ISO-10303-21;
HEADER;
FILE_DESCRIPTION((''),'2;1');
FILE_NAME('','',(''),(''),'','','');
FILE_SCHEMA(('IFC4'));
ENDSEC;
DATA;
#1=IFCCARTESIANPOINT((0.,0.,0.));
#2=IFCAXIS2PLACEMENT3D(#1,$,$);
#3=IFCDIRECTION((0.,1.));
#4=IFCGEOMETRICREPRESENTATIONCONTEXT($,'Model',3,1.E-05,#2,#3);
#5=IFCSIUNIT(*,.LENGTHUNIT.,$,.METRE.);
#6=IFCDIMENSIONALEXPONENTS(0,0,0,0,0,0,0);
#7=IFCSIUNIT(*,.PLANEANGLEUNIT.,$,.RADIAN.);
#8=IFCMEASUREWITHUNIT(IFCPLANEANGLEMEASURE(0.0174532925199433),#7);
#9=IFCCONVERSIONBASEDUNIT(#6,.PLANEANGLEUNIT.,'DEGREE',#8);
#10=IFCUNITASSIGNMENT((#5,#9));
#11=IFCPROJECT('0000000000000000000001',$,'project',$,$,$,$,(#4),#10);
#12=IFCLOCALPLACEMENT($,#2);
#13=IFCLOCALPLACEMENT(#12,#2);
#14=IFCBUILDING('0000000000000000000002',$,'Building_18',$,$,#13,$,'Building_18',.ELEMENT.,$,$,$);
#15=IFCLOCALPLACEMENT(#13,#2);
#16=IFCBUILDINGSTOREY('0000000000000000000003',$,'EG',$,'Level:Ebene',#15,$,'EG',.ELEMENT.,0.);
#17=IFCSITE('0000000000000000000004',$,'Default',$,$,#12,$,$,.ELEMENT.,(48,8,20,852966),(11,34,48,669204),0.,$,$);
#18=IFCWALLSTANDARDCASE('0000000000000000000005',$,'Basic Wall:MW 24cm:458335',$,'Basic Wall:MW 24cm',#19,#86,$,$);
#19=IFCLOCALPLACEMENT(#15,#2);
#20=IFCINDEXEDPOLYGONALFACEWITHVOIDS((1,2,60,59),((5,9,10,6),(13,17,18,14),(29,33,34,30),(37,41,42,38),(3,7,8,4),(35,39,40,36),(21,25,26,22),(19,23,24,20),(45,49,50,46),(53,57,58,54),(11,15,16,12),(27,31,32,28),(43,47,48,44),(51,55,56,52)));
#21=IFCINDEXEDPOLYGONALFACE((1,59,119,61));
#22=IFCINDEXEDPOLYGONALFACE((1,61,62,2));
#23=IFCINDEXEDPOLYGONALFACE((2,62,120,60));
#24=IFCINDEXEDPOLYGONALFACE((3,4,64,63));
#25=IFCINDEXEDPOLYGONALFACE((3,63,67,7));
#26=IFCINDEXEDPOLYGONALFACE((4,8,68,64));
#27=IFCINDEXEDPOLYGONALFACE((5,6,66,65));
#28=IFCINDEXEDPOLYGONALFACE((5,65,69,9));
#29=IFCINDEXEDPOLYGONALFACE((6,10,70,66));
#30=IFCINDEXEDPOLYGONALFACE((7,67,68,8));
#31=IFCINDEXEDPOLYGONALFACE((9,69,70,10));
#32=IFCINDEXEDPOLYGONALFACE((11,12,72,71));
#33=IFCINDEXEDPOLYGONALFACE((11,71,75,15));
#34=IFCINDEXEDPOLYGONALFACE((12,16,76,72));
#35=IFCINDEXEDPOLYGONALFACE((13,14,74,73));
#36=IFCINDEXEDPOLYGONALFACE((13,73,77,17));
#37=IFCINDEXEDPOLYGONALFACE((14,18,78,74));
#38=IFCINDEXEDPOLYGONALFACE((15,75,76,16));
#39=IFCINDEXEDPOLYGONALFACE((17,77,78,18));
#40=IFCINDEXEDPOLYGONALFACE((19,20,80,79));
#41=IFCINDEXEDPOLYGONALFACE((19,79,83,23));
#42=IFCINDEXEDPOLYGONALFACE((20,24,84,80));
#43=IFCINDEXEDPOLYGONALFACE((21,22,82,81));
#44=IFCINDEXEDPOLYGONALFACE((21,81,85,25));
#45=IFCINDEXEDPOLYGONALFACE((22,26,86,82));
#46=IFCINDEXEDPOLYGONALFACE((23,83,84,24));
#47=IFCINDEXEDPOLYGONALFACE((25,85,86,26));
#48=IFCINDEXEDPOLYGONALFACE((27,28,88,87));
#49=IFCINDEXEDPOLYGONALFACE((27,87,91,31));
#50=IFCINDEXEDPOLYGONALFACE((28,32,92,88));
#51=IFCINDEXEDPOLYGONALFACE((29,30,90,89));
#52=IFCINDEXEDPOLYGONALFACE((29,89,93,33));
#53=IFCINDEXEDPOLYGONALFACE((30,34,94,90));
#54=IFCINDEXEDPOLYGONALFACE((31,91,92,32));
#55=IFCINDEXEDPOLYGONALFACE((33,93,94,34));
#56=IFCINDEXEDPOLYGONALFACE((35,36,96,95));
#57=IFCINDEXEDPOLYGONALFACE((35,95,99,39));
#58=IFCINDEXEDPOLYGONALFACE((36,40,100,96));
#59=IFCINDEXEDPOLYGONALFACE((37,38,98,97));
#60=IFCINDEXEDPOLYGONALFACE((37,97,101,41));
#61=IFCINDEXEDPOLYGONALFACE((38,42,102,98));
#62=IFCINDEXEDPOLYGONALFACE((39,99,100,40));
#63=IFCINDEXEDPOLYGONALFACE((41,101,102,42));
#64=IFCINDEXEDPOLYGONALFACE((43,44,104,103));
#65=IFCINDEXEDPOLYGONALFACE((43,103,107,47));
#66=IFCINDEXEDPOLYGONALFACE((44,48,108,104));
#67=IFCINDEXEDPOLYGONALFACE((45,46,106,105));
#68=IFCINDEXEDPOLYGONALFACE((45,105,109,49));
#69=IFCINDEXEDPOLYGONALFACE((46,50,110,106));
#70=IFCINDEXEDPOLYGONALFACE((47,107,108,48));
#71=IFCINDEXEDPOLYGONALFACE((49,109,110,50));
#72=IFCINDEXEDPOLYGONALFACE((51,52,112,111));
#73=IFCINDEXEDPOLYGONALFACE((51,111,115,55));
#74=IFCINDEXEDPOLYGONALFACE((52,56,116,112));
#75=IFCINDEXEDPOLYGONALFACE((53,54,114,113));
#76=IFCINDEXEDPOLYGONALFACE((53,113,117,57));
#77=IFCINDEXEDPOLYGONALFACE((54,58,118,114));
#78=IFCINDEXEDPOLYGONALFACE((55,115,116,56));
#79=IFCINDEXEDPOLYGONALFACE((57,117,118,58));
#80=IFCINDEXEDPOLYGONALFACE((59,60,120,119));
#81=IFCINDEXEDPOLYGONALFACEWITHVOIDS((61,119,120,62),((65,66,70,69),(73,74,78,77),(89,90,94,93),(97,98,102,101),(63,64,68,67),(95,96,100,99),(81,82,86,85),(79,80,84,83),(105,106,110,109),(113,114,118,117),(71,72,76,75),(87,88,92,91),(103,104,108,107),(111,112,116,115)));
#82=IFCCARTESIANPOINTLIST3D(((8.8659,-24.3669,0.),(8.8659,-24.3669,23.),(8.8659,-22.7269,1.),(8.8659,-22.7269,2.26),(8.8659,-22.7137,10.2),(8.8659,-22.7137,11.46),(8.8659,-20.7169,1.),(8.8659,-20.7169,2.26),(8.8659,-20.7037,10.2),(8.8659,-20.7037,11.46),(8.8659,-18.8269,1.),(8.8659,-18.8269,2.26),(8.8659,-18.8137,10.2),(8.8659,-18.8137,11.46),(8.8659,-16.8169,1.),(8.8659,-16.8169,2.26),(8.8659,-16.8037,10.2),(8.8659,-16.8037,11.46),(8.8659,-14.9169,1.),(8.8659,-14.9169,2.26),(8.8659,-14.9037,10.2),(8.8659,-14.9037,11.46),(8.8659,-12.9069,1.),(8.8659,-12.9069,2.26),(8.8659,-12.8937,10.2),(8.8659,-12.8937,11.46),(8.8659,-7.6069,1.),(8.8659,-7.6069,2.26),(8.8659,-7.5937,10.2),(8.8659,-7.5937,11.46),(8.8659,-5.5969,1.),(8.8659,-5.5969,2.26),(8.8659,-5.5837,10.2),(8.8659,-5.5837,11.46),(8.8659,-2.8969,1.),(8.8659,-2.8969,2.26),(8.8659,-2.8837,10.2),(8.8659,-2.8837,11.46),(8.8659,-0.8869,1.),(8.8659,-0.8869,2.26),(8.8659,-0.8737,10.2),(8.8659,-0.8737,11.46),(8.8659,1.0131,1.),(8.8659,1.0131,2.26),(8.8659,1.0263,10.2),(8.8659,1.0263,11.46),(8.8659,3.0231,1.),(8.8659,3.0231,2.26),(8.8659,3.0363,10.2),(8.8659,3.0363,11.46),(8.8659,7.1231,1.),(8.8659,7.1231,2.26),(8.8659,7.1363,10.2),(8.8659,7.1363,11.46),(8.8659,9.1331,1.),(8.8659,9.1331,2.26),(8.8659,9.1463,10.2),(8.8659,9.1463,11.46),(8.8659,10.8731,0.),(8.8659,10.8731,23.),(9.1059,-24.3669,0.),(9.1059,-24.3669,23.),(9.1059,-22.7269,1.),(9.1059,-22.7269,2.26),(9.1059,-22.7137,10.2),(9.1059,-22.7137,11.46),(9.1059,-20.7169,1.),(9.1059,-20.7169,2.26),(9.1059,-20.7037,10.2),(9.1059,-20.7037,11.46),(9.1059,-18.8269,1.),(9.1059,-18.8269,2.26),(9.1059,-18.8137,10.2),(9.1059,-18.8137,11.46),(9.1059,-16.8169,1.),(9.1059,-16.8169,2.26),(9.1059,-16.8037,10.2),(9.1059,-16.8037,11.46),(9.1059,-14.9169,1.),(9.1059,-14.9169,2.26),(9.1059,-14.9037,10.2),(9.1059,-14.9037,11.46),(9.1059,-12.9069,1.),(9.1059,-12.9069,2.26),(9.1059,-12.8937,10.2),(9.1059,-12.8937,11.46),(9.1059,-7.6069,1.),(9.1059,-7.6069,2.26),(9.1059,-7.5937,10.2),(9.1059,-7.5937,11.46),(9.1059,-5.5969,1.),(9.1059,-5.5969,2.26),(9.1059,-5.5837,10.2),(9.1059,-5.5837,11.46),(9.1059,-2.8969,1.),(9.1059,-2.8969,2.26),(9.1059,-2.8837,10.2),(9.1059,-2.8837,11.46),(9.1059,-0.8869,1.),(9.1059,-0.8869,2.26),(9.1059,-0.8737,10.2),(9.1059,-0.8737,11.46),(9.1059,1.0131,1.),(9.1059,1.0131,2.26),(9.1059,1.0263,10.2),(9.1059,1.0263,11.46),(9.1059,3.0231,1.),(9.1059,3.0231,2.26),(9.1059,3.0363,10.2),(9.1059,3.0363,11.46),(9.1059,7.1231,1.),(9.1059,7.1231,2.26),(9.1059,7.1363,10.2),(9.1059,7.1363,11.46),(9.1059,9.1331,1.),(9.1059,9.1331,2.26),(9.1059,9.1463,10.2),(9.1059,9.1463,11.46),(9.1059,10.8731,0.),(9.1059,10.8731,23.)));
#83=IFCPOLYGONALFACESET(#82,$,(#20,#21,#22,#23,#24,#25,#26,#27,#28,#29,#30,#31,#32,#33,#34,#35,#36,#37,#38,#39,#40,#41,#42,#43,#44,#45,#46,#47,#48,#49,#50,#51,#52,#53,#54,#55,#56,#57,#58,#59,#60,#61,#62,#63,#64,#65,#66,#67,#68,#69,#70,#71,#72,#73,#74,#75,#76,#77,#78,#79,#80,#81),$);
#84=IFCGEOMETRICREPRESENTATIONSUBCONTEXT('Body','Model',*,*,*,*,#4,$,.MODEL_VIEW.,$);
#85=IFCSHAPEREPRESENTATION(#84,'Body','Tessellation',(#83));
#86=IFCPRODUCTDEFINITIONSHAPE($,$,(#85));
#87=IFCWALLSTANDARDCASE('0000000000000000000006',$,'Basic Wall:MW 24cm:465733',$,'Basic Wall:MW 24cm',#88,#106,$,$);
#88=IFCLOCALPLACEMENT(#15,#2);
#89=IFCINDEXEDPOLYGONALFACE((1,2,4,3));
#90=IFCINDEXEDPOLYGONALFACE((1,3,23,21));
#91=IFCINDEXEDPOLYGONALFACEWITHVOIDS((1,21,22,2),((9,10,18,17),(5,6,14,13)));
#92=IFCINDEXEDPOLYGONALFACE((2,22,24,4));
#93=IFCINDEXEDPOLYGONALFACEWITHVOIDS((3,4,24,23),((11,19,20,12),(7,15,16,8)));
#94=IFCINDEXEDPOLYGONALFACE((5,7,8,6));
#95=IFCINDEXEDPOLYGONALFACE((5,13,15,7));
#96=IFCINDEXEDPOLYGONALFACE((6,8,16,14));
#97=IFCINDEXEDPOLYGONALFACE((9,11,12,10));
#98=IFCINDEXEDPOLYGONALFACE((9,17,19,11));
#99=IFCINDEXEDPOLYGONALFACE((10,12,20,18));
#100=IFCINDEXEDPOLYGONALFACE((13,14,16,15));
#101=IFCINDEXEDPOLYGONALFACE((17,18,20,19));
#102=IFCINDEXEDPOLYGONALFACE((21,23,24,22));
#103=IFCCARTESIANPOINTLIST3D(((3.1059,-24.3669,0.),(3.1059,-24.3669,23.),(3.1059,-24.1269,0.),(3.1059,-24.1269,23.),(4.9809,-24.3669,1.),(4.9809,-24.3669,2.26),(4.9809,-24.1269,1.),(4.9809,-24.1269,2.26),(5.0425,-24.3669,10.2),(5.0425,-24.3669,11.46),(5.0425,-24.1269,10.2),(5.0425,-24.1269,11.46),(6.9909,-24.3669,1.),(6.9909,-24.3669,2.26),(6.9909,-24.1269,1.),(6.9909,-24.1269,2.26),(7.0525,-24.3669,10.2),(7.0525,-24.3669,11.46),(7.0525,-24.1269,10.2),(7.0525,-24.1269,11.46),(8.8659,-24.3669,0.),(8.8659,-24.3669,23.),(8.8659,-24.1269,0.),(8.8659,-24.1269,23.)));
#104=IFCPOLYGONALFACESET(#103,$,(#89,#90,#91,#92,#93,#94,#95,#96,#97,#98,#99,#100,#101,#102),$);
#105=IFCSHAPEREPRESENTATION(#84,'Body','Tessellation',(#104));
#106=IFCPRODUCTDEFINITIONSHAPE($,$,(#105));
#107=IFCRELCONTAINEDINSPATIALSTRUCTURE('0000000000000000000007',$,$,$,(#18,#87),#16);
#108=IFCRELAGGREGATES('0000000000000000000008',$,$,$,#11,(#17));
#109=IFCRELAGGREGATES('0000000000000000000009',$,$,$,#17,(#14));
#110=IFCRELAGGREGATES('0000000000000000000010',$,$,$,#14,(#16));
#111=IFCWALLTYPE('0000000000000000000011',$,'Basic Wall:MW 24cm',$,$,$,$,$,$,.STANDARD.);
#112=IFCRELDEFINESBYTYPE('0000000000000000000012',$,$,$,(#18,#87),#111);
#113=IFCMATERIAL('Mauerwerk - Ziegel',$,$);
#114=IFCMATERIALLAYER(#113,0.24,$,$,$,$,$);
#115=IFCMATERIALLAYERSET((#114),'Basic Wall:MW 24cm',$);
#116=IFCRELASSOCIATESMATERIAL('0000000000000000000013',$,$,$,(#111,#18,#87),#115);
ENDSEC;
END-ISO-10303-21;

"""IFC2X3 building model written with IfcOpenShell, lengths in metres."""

from ifc_helpers import new_model, entity, si_unit, converted_unit, direction, frame, frame_2d, origin, place, context, subcontext, project, spatial, rectangle, extrude, material, layer, layer_set, layer_usage, type_object, element, save


model = new_model("IFC2X3")

# Units and contexts
model_context = context("Model", 3, precision=1e-05, world=origin(), true_north=direction((0.0, 1.0)))
body_context = subcontext(model_context, "Body", "Model", "MODEL_VIEW")
ifc_project = project(units=[si_unit("LENGTHUNIT", "METRE"), converted_unit("PLANEANGLEUNIT", "DEGREE", entity("IfcPlaneAngleMeasure", 0.0174532925199433), si_unit("PLANEANGLEUNIT", "RADIAN"), dimensions=[0, 0, 0, 0, 0, 0, 0])], contexts=[model_context])

# Site, building, storey
site_placement = place(None, origin())
site = spatial("IfcSite", under=ifc_project, at=site_placement, Name="Default", CompositionType="ELEMENT", RefLatitude=(48, 8, 20, 852966), RefLongitude=(11, 34, 48, 669204), RefElevation=0.0)
building_placement = place(site_placement, origin())
building = spatial("IfcBuilding", under=site, at=building_placement, Name="Building_18", LongName="Building_18", CompositionType="ELEMENT")
storey_placement = place(building_placement, origin())
storey = spatial("IfcBuildingStorey", under=building, at=storey_placement, Name="EG", ObjectType="Level:Ebene", LongName="EG", CompositionType="ELEMENT", Elevation=0.0)

# Walls, openings
ifc_material_1 = material(Name="Mauerwerk - Ziegel")
ifc_layer = layer(ifc_material_1, 0.24)
ifc_layer_set = layer_set([ifc_layer], Name="Basic Wall:MW 24cm")
wall_type = type_object("IfcWallType", Name="Basic Wall:MW 24cm", PredefinedType="STANDARD", material=ifc_layer_set)
ifc_layer_usage_1 = layer_usage(ifc_layer_set, "AXIS2", "NEGATIVE", 0.12)
wall_1_placement = place(storey_placement, frame((8.9859, -24.3669, 0.0), z_axis=(0.0, 0.0, 1.0), x_axis=(0.0, 1.0, 0.0)))
wall_1 = element("IfcWallStandardCase", 1, at=wall_1_placement, inside=storey, type_object=wall_type, material=ifc_layer_usage_1, Name="Basic Wall:MW 24cm:458335", ObjectType="Basic Wall:MW 24cm", context=body_context, shape_type="SweptSolid", body=[
    extrude(rectangle(XDim=35.24, YDim=0.24, at=frame_2d((17.62, 0.0), x_axis=(-1.0, 0.0))), origin(), (0.0, 0.0, 1.0), 23.0),
])
opening_1_placement = place(wall_1_placement, frame((31.49, -0.12, 1.0)))
element("IfcOpeningElement", 2, at=opening_1_placement, cuts=wall_1, ObjectType="Opening", context=body_context, shape_type="SweptSolid", body=[
    extrude(rectangle(XDim=1.26, YDim=2.01, at=frame_2d((0.63, 1.005), x_axis=(1.0, 0.0))), frame((0.0, 0.0, 0.0), z_axis=(0.0, 1.0, 0.0), x_axis=(0.0, 0.0, 1.0)), (0.0, 0.0, 1.0), 0.24),
])
opening_2_placement = place(wall_1_placement, frame((25.38, -0.12, 1.0)))
element("IfcOpeningElement", 3, at=opening_2_placement, cuts=wall_1, ObjectType="Opening", context=body_context, shape_type="SweptSolid", body=[
    extrude(rectangle(XDim=1.26, YDim=2.01, at=frame_2d((0.63, 1.005), x_axis=(1.0, 0.0))), frame((0.0, 0.0, 0.0), z_axis=(0.0, 1.0, 0.0), x_axis=(0.0, 0.0, 1.0)), (0.0, 0.0, 1.0), 0.24),
])
opening_3_placement = place(wall_1_placement, frame((21.47, -0.12, 1.0)))
element("IfcOpeningElement", 4, at=opening_3_placement, cuts=wall_1, ObjectType="Opening", context=body_context, shape_type="SweptSolid", body=[
    extrude(rectangle(XDim=1.26, YDim=2.01, at=frame_2d((0.63, 1.005), x_axis=(1.0, 0.0))), frame((0.0, 0.0, 0.0), z_axis=(0.0, 1.0, 0.0), x_axis=(0.0, 0.0, 1.0)), (0.0, 0.0, 1.0), 0.24),
])
opening_4_placement = place(wall_1_placement, frame((16.76, -0.12, 1.0)))
element("IfcOpeningElement", 5, at=opening_4_placement, cuts=wall_1, ObjectType="Opening", context=body_context, shape_type="SweptSolid", body=[
    extrude(rectangle(XDim=1.26, YDim=2.01, at=frame_2d((0.63, 1.005), x_axis=(1.0, 0.0))), frame((0.0, 0.0, 0.0), z_axis=(0.0, 1.0, 0.0), x_axis=(0.0, 0.0, 1.0)), (0.0, 0.0, 1.0), 0.24),
])
opening_5_placement = place(wall_1_placement, frame((9.45, -0.12, 1.0)))
element("IfcOpeningElement", 6, at=opening_5_placement, cuts=wall_1, ObjectType="Opening", context=body_context, shape_type="SweptSolid", body=[
    extrude(rectangle(XDim=1.26, YDim=2.01, at=frame_2d((0.63, 1.005), x_axis=(1.0, 0.0))), frame((0.0, 0.0, 0.0), z_axis=(0.0, 1.0, 0.0), x_axis=(0.0, 0.0, 1.0)), (0.0, 0.0, 1.0), 0.24),
])
opening_6_placement = place(wall_1_placement, frame((5.54, -0.12, 1.0)))
element("IfcOpeningElement", 7, at=opening_6_placement, cuts=wall_1, ObjectType="Opening", context=body_context, shape_type="SweptSolid", body=[
    extrude(rectangle(XDim=1.26, YDim=2.01, at=frame_2d((0.63, 1.005), x_axis=(1.0, 0.0))), frame((0.0, 0.0, 0.0), z_axis=(0.0, 1.0, 0.0), x_axis=(0.0, 0.0, 1.0)), (0.0, 0.0, 1.0), 0.24),
])
opening_7_placement = place(wall_1_placement, frame((1.64, -0.12, 1.0)))
element("IfcOpeningElement", 8, at=opening_7_placement, cuts=wall_1, ObjectType="Opening", context=body_context, shape_type="SweptSolid", body=[
    extrude(rectangle(XDim=1.26, YDim=2.01, at=frame_2d((0.63, 1.005), x_axis=(1.0, 0.0))), frame((0.0, 0.0, 0.0), z_axis=(0.0, 1.0, 0.0), x_axis=(0.0, 0.0, 1.0)), (0.0, 0.0, 1.0), 0.24),
])
opening_8_placement = place(wall_1_placement, frame((31.5032, -0.12, 10.2)))
element("IfcOpeningElement", 9, at=opening_8_placement, cuts=wall_1, ObjectType="Opening", context=body_context, shape_type="SweptSolid", body=[
    extrude(rectangle(XDim=1.26, YDim=2.01, at=frame_2d((0.63, 1.005), x_axis=(1.0, 0.0))), frame((0.0, 0.0, 0.0), z_axis=(0.0, 1.0, 0.0), x_axis=(0.0, 0.0, 1.0)), (0.0, 0.0, 1.0), 0.24),
])
opening_9_placement = place(wall_1_placement, frame((25.3932, -0.12, 10.2)))
element("IfcOpeningElement", 10, at=opening_9_placement, cuts=wall_1, ObjectType="Opening", context=body_context, shape_type="SweptSolid", body=[
    extrude(rectangle(XDim=1.26, YDim=2.01, at=frame_2d((0.63, 1.005), x_axis=(1.0, 0.0))), frame((0.0, 0.0, 0.0), z_axis=(0.0, 1.0, 0.0), x_axis=(0.0, 0.0, 1.0)), (0.0, 0.0, 1.0), 0.24),
])
opening_10_placement = place(wall_1_placement, frame((21.4832, -0.12, 10.2)))
element("IfcOpeningElement", 11, at=opening_10_placement, cuts=wall_1, ObjectType="Opening", context=body_context, shape_type="SweptSolid", body=[
    extrude(rectangle(XDim=1.26, YDim=2.01, at=frame_2d((0.63, 1.005), x_axis=(1.0, 0.0))), frame((0.0, 0.0, 0.0), z_axis=(0.0, 1.0, 0.0), x_axis=(0.0, 0.0, 1.0)), (0.0, 0.0, 1.0), 0.24),
])
opening_11_placement = place(wall_1_placement, frame((16.7732, -0.12, 10.2)))
element("IfcOpeningElement", 12, at=opening_11_placement, cuts=wall_1, ObjectType="Opening", context=body_context, shape_type="SweptSolid", body=[
    extrude(rectangle(XDim=1.26, YDim=2.01, at=frame_2d((0.63, 1.005), x_axis=(1.0, 0.0))), frame((0.0, 0.0, 0.0), z_axis=(0.0, 1.0, 0.0), x_axis=(0.0, 0.0, 1.0)), (0.0, 0.0, 1.0), 0.24),
])
opening_12_placement = place(wall_1_placement, frame((9.4632, -0.12, 10.2)))
element("IfcOpeningElement", 13, at=opening_12_placement, cuts=wall_1, ObjectType="Opening", context=body_context, shape_type="SweptSolid", body=[
    extrude(rectangle(XDim=1.26, YDim=2.01, at=frame_2d((0.63, 1.005), x_axis=(1.0, 0.0))), frame((0.0, 0.0, 0.0), z_axis=(0.0, 1.0, 0.0), x_axis=(0.0, 0.0, 1.0)), (0.0, 0.0, 1.0), 0.24),
])
opening_13_placement = place(wall_1_placement, frame((5.5532, -0.12, 10.2)))
element("IfcOpeningElement", 14, at=opening_13_placement, cuts=wall_1, ObjectType="Opening", context=body_context, shape_type="SweptSolid", body=[
    extrude(rectangle(XDim=1.26, YDim=2.01, at=frame_2d((0.63, 1.005), x_axis=(1.0, 0.0))), frame((0.0, 0.0, 0.0), z_axis=(0.0, 1.0, 0.0), x_axis=(0.0, 0.0, 1.0)), (0.0, 0.0, 1.0), 0.24),
])
opening_14_placement = place(wall_1_placement, frame((1.6532, -0.12, 10.2)))
element("IfcOpeningElement", 15, at=opening_14_placement, cuts=wall_1, ObjectType="Opening", context=body_context, shape_type="SweptSolid", body=[
    extrude(rectangle(XDim=1.26, YDim=2.01, at=frame_2d((0.63, 1.005), x_axis=(1.0, 0.0))), frame((0.0, 0.0, 0.0), z_axis=(0.0, 1.0, 0.0), x_axis=(0.0, 0.0, 1.0)), (0.0, 0.0, 1.0), 0.24),
])
ifc_layer_usage_2 = layer_usage(ifc_layer_set, "AXIS2", "NEGATIVE", 0.12)
wall_2_placement = place(storey_placement, frame((3.1059, -24.2469, 0.0)))
wall_2 = element("IfcWallStandardCase", 16, at=wall_2_placement, inside=storey, type_object=wall_type, material=ifc_layer_usage_2, Name="Basic Wall:MW 24cm:465733", ObjectType="Basic Wall:MW 24cm", context=body_context, shape_type="SweptSolid", body=[
    extrude(rectangle(XDim=5.76, YDim=0.24, at=frame_2d((2.88, 0.0), x_axis=(-1.0, 0.0))), origin(), (0.0, 0.0, 1.0), 23.0),
])
opening_15_placement = place(wall_2_placement, frame((3.885, 0.12, 1.0)))
element("IfcOpeningElement", 17, at=opening_15_placement, cuts=wall_2, ObjectType="Opening", context=body_context, shape_type="SweptSolid", body=[
    extrude(rectangle(XDim=1.26, YDim=2.01, at=frame_2d((0.63, 1.005), x_axis=(1.0, 0.0))), frame((0.0, 0.0, 0.0), z_axis=(0.0, -1.0, 0.0), x_axis=(0.0, 0.0, 1.0)), (0.0, 0.0, 1.0), 0.24),
])
opening_16_placement = place(wall_2_placement, frame((3.9465, 0.12, 10.2)))
element("IfcOpeningElement", 18, at=opening_16_placement, cuts=wall_2, ObjectType="Opening", context=body_context, shape_type="SweptSolid", body=[
    extrude(rectangle(XDim=1.26, YDim=2.01, at=frame_2d((0.63, 1.005), x_axis=(1.0, 0.0))), frame((0.0, 0.0, 0.0), z_axis=(0.0, -1.0, 0.0), x_axis=(0.0, 0.0, 1.0)), (0.0, 0.0, 1.0), 0.24),
])

save(model, "model.ifc")
